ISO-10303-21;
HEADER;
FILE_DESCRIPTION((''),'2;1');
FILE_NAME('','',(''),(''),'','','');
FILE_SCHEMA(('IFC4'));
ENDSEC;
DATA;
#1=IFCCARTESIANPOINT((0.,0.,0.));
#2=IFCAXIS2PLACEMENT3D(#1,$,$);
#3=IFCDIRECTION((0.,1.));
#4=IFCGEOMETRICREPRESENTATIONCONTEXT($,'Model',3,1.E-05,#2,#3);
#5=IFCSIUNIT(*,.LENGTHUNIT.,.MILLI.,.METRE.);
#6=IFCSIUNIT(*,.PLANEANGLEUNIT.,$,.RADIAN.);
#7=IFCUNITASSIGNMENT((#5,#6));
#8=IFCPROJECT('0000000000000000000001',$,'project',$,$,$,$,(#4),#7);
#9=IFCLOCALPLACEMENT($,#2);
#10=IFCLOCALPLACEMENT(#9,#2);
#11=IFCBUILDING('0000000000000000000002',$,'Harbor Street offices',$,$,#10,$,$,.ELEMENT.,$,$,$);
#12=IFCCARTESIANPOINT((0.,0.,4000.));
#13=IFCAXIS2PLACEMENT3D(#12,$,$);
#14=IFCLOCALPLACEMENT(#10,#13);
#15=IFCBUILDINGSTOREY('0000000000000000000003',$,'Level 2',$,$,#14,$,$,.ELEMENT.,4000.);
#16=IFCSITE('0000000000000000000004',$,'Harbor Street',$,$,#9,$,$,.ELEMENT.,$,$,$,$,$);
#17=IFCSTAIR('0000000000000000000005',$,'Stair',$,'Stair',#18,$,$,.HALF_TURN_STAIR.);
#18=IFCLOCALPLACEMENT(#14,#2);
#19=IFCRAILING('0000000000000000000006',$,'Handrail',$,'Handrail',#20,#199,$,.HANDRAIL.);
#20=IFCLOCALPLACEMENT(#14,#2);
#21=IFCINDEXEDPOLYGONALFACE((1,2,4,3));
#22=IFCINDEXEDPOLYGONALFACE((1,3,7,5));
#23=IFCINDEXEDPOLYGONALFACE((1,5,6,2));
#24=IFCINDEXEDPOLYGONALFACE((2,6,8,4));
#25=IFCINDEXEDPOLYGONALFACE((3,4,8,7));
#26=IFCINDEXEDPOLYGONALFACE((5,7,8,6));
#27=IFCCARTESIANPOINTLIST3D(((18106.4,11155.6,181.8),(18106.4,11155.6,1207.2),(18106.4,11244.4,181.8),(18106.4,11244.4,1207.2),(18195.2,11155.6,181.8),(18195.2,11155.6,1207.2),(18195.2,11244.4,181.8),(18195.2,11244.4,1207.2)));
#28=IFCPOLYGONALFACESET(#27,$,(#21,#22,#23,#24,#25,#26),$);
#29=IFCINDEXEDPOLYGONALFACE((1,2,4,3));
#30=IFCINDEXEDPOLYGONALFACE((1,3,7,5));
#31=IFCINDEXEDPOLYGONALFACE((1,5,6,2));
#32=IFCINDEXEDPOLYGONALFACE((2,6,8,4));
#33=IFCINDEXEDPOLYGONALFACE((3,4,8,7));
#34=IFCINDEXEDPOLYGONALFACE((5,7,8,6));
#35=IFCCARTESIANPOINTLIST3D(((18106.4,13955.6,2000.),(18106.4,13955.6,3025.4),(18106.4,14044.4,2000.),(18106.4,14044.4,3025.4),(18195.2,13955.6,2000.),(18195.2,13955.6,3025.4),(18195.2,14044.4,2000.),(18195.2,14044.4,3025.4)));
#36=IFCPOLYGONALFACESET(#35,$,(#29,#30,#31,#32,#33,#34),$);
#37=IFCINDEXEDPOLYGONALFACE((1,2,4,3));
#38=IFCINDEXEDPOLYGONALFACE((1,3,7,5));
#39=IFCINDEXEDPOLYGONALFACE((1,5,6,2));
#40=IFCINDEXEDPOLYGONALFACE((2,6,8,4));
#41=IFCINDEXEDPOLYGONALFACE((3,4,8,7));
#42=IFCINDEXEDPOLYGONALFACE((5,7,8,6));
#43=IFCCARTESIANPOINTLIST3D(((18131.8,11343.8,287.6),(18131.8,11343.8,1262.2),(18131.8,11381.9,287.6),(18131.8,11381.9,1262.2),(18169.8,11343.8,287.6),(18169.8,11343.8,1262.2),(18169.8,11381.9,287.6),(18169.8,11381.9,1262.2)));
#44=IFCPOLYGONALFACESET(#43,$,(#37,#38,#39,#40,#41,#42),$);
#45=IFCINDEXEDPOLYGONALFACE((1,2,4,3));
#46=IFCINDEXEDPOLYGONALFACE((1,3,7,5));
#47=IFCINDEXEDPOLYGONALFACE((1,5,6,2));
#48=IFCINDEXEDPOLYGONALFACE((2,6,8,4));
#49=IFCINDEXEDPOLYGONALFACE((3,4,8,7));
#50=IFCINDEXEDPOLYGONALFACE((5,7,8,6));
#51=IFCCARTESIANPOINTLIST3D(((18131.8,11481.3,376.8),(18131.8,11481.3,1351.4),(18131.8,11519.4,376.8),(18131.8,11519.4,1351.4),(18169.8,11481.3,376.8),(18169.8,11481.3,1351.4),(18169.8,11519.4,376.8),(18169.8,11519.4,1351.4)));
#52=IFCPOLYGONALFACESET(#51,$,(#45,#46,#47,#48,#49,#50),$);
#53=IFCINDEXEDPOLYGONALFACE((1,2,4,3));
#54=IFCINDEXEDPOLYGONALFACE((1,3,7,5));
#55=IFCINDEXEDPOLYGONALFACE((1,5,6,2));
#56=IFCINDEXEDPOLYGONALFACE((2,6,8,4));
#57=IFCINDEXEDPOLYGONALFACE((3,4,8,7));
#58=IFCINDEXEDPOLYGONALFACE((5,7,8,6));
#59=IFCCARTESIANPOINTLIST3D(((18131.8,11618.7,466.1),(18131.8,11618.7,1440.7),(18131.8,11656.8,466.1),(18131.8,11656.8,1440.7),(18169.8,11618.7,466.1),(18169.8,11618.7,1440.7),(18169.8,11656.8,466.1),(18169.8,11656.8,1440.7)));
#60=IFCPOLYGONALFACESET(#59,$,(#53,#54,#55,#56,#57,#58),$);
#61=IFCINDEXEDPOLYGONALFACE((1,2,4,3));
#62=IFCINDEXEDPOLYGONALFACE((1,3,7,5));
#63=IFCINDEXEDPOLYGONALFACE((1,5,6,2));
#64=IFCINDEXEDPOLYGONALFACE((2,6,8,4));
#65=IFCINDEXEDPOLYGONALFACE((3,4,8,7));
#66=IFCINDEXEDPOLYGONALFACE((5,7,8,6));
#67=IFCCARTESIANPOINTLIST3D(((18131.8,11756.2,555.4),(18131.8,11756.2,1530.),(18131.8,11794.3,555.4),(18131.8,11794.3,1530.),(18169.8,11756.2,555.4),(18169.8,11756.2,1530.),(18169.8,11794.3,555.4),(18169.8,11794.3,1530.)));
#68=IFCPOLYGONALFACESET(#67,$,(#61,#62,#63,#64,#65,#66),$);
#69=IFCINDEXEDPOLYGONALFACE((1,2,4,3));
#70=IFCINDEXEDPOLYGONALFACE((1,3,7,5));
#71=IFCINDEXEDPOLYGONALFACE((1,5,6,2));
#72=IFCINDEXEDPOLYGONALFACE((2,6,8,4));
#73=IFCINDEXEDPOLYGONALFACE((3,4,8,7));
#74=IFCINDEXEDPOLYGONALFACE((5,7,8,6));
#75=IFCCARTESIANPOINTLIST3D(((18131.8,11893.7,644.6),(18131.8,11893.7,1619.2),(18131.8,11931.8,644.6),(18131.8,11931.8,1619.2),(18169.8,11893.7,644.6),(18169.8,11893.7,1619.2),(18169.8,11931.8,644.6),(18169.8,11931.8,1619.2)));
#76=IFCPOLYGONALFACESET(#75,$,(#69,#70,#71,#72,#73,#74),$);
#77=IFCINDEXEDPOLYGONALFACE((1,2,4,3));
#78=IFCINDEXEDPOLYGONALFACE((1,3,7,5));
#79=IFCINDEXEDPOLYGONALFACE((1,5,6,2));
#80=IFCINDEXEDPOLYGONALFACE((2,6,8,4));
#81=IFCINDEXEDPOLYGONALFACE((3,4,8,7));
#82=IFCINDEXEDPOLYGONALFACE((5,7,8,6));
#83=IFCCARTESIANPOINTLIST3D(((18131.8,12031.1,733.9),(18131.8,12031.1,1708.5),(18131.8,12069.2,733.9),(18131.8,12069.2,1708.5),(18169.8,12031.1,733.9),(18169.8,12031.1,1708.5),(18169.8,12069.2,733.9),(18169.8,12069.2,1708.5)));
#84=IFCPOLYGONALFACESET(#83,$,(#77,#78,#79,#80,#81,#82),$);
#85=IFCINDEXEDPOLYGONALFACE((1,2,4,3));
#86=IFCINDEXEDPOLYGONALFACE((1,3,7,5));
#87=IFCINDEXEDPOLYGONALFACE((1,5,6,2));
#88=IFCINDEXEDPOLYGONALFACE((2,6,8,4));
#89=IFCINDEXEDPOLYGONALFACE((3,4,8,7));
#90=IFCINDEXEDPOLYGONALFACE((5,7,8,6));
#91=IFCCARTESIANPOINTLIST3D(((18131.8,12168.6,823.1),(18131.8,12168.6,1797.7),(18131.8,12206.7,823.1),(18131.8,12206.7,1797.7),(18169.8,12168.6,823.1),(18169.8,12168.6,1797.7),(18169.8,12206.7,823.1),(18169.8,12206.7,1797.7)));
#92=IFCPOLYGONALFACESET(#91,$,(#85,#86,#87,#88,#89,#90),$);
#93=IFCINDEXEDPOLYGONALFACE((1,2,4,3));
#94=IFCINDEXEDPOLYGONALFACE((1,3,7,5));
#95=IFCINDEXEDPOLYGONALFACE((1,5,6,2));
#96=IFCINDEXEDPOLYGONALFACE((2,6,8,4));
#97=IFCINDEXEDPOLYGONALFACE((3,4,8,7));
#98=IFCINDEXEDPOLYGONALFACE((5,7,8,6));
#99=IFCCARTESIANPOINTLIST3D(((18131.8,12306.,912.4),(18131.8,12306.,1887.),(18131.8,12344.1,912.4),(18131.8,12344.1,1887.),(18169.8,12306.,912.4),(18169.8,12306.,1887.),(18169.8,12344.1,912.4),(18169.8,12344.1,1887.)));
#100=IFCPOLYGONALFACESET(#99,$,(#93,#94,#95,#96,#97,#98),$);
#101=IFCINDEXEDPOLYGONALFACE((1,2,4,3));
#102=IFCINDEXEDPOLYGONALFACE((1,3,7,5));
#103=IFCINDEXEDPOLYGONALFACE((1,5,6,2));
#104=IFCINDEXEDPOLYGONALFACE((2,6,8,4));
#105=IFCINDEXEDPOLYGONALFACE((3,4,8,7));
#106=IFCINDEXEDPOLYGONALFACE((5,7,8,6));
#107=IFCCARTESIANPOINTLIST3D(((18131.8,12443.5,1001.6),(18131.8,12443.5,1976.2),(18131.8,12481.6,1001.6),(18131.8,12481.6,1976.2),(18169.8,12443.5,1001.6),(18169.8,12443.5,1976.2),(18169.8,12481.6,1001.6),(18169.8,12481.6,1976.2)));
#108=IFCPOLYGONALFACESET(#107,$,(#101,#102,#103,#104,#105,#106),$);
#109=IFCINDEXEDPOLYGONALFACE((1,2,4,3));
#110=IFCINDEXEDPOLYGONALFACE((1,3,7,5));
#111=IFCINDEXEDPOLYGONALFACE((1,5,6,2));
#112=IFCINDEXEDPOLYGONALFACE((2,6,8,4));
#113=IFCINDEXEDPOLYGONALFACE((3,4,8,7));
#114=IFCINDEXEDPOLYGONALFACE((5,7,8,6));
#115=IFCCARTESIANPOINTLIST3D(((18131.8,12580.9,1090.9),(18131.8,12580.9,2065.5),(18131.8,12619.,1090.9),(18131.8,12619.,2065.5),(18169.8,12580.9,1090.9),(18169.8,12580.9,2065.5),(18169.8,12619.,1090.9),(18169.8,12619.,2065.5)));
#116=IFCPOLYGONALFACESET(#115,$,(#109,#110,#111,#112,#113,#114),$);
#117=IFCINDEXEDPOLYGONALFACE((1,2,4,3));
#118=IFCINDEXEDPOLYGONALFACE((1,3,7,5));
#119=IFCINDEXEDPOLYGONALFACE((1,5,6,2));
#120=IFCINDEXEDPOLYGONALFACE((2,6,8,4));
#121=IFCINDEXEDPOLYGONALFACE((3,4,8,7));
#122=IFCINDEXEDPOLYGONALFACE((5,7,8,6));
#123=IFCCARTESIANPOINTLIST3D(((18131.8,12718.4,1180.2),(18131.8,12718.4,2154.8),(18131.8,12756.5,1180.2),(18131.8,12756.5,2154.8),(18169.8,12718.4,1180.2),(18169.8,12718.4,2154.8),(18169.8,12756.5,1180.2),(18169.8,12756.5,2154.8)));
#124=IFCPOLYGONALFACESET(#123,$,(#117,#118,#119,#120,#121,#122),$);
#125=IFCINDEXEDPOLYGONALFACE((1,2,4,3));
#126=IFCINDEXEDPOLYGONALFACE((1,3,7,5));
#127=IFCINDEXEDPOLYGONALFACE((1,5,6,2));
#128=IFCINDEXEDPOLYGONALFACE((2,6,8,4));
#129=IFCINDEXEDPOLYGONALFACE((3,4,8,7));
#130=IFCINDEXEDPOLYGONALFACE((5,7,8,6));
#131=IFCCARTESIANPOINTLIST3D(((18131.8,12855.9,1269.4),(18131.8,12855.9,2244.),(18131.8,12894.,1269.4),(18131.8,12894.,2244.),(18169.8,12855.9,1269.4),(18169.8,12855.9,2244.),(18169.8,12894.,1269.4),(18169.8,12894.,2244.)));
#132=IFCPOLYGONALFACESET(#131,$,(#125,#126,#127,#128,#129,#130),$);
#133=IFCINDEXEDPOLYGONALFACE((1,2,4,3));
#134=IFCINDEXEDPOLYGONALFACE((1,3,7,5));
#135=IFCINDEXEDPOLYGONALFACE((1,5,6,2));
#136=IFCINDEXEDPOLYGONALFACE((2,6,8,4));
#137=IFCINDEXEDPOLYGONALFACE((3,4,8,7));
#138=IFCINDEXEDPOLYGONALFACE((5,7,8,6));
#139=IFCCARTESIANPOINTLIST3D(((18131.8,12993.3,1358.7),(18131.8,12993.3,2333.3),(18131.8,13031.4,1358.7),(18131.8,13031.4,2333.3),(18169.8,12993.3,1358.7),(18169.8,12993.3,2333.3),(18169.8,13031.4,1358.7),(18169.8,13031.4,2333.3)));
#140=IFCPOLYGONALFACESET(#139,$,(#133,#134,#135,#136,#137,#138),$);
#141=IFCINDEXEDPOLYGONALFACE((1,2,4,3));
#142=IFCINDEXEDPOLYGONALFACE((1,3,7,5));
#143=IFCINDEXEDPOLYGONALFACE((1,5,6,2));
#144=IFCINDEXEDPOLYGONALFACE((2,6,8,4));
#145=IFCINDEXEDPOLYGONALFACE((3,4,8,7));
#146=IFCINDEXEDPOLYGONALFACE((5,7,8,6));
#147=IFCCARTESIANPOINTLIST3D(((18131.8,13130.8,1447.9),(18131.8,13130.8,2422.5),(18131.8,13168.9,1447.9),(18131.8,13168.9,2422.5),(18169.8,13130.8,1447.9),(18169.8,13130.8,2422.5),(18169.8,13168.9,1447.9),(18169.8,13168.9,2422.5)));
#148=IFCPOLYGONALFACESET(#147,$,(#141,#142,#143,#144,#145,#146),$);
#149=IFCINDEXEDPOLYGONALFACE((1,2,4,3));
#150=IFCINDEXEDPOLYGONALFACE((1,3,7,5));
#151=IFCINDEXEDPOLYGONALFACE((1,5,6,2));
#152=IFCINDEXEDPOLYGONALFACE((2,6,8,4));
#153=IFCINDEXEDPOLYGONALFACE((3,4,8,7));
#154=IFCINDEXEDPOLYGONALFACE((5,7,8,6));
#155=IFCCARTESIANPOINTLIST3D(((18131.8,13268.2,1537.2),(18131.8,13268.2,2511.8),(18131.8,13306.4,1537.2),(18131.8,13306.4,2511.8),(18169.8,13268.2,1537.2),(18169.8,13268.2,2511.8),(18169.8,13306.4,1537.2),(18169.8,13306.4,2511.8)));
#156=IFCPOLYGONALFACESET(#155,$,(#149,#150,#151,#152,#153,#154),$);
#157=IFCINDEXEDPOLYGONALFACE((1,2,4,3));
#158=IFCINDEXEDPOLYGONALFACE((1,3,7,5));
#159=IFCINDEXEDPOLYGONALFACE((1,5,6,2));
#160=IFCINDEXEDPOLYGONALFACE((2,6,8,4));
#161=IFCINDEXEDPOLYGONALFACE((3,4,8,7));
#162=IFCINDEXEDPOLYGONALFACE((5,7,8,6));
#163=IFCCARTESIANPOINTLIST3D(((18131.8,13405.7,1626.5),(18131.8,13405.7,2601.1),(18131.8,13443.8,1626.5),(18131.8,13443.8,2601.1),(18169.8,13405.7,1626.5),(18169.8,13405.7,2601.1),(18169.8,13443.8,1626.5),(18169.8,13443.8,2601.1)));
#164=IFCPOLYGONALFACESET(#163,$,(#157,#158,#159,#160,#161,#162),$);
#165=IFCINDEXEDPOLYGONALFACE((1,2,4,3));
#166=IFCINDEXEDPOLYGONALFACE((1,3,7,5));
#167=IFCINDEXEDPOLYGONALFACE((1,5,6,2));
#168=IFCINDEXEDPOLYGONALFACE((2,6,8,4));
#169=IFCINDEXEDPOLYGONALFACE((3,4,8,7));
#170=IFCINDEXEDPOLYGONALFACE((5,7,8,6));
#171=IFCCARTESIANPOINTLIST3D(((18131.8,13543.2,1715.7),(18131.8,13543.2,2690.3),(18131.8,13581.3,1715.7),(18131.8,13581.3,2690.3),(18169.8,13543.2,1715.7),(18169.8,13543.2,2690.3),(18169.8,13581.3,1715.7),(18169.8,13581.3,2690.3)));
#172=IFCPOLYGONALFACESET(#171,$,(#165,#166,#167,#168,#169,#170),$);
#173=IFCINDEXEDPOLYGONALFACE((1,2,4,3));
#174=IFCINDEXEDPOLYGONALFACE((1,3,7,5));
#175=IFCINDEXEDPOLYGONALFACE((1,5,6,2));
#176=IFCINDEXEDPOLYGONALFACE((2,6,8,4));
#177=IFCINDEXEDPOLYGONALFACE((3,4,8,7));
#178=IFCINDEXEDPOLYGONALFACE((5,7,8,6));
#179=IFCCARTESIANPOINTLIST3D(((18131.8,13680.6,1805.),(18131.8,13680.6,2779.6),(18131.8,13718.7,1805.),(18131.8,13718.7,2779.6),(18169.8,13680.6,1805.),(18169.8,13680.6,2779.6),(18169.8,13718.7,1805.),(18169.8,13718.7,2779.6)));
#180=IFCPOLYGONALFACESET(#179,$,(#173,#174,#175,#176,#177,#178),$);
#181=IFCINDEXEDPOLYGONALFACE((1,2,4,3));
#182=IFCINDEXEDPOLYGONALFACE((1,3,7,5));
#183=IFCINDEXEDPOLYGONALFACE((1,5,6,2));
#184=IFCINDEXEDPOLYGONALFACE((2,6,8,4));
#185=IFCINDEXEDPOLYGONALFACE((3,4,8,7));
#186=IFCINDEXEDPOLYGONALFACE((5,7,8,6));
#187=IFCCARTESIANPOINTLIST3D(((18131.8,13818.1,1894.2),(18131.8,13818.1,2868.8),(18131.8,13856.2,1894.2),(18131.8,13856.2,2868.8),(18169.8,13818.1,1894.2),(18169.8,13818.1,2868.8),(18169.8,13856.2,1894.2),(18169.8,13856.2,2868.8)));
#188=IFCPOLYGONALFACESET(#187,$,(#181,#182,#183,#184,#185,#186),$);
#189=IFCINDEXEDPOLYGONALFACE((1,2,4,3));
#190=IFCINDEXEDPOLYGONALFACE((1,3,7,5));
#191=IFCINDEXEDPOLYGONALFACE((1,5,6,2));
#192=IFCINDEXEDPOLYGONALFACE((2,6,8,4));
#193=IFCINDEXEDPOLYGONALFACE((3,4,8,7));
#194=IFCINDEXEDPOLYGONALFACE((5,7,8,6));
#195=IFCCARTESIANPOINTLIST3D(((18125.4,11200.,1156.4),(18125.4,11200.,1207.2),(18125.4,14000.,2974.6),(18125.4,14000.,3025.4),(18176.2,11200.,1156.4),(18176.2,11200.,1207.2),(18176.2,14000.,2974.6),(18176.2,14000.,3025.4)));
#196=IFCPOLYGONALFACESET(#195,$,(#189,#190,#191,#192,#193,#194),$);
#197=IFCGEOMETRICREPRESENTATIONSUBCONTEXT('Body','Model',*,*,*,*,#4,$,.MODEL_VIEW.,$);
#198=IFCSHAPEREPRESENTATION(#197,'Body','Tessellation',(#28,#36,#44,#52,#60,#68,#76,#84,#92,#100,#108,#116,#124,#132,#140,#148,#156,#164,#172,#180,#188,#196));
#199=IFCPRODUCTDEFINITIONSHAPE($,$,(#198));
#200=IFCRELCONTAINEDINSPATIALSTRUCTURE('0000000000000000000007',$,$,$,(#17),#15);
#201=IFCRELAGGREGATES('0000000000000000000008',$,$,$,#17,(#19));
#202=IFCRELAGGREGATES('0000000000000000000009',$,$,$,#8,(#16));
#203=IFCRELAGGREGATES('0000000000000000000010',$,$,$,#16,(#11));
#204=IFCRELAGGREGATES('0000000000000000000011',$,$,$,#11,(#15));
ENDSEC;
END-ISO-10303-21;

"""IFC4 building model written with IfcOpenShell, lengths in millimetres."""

from ifc_helpers import new_model, si_unit, direction, frame, origin, origin_with_axes, place, context, subcontext, project, spatial, polyline, outline, extrude, element, aggregate, save


model = new_model("IFC4")

# Units and contexts
model_context = context("Model", 3, precision=1e-05, world=origin(), true_north=direction((0.0, 1.0)))
body_context = subcontext(model_context, "Body", "Model", "MODEL_VIEW")
ifc_project = project(units=[si_unit("LENGTHUNIT", "METRE", prefix="MILLI"), si_unit("PLANEANGLEUNIT", "RADIAN")], contexts=[model_context])

# Site, building, storey
site_placement = place(None, origin())
site = spatial("IfcSite", under=ifc_project, at=site_placement, Name="Harbor Street", CompositionType="ELEMENT")
building_placement = place(site_placement, origin())
building = spatial("IfcBuilding", under=site, at=building_placement, Name="Harbor Street offices", CompositionType="ELEMENT")
storey_placement = place(building_placement, frame((0.0, 0.0, 4000.0)))
storey = spatial("IfcBuildingStorey", under=building, at=storey_placement, Name="Level 2", CompositionType="ELEMENT", Elevation=4000.0)

# Stair
stair_placement = place(storey_placement, origin_with_axes())
stair = element("IfcStair", 1, at=stair_placement, inside=storey, Name="Stair", ObjectType="Stair", PredefinedType="HALF_TURN_STAIR")

# Railing
railing_1_placement = place(storey_placement, origin_with_axes())
railing_1 = element("IfcRailing", 2, at=railing_1_placement, Name="Handrail", ObjectType="Handrail", PredefinedType="HANDRAIL", context=body_context, shape_type="SweptSolid", body=[
    extrude(outline(polyline([(-44.5, -44.5), (44.5, -44.5), (44.5, 44.5), (-44.5, 44.5), (-44.5, -44.5)])), frame((18150.8, 11200.0, 181.8), z_axis=(0.0, 0.0, 1.0), x_axis=(1.0, 0.0, 0.0)), (0.0, 0.0, 1.0), 1025.4),
    extrude(outline(polyline([(-44.5, -44.5), (44.5, -44.5), (44.5, 44.5), (-44.5, 44.5), (-44.5, -44.5)])), frame((18150.8, 14000.0, 2000.0), z_axis=(0.0, 0.0, 1.0), x_axis=(1.0, 0.0, 0.0)), (0.0, 0.0, 1.0), 1025.4),
    extrude(outline(polyline([(-19.1, -19.1), (19.1, -19.1), (19.1, 19.1), (-19.1, 19.1), (-19.1, -19.1)])), frame((18150.8, 11362.9, 287.6), z_axis=(0.0, 0.0, 1.0), x_axis=(1.0, 0.0, 0.0)), (0.0, 0.0, 1.0), 974.6),
    extrude(outline(polyline([(-19.1, -19.1), (19.1, -19.1), (19.1, 19.1), (-19.1, 19.1), (-19.1, -19.1)])), frame((18150.8, 11500.3, 376.8), z_axis=(0.0, 0.0, 1.0), x_axis=(1.0, 0.0, 0.0)), (0.0, 0.0, 1.0), 974.6),
    extrude(outline(polyline([(-19.1, -19.1), (19.1, -19.1), (19.1, 19.1), (-19.1, 19.1), (-19.1, -19.1)])), frame((18150.8, 11637.8, 466.1), z_axis=(0.0, 0.0, 1.0), x_axis=(1.0, 0.0, 0.0)), (0.0, 0.0, 1.0), 974.6),
    extrude(outline(polyline([(-19.1, -19.1), (19.1, -19.1), (19.1, 19.1), (-19.1, 19.1), (-19.1, -19.1)])), frame((18150.8, 11775.2, 555.4), z_axis=(0.0, 0.0, 1.0), x_axis=(1.0, 0.0, 0.0)), (0.0, 0.0, 1.0), 974.6),
    extrude(outline(polyline([(-19.1, -19.1), (19.1, -19.1), (19.1, 19.1), (-19.1, 19.1), (-19.1, -19.1)])), frame((18150.8, 11912.7, 644.6), z_axis=(0.0, 0.0, 1.0), x_axis=(1.0, 0.0, 0.0)), (0.0, 0.0, 1.0), 974.6),
    extrude(outline(polyline([(-19.1, -19.1), (19.1, -19.1), (19.1, 19.1), (-19.1, 19.1), (-19.1, -19.1)])), frame((18150.8, 12050.2, 733.9), z_axis=(0.0, 0.0, 1.0), x_axis=(1.0, 0.0, 0.0)), (0.0, 0.0, 1.0), 974.6),
    extrude(outline(polyline([(-19.1, -19.1), (19.1, -19.1), (19.1, 19.1), (-19.1, 19.1), (-19.1, -19.1)])), frame((18150.8, 12187.6, 823.1), z_axis=(0.0, 0.0, 1.0), x_axis=(1.0, 0.0, 0.0)), (0.0, 0.0, 1.0), 974.6),
    extrude(outline(polyline([(-19.1, -19.1), (19.1, -19.1), (19.1, 19.1), (-19.1, 19.1), (-19.1, -19.1)])), frame((18150.8, 12325.1, 912.4), z_axis=(0.0, 0.0, 1.0), x_axis=(1.0, 0.0, 0.0)), (0.0, 0.0, 1.0), 974.6),
    extrude(outline(polyline([(-19.1, -19.1), (19.1, -19.1), (19.1, 19.1), (-19.1, 19.1), (-19.1, -19.1)])), frame((18150.8, 12462.5, 1001.6), z_axis=(0.0, 0.0, 1.0), x_axis=(1.0, 0.0, 0.0)), (0.0, 0.0, 1.0), 974.6),
    extrude(outline(polyline([(-19.1, -19.1), (19.1, -19.1), (19.1, 19.1), (-19.1, 19.1), (-19.1, -19.1)])), frame((18150.8, 12600.0, 1090.9), z_axis=(0.0, 0.0, 1.0), x_axis=(1.0, 0.0, 0.0)), (0.0, 0.0, 1.0), 974.6),
    extrude(outline(polyline([(-19.1, -19.1), (19.1, -19.1), (19.1, 19.1), (-19.1, 19.1), (-19.1, -19.1)])), frame((18150.8, 12737.5, 1180.2), z_axis=(0.0, 0.0, 1.0), x_axis=(1.0, 0.0, 0.0)), (0.0, 0.0, 1.0), 974.6),
    extrude(outline(polyline([(-19.1, -19.1), (19.1, -19.1), (19.1, 19.1), (-19.1, 19.1), (-19.1, -19.1)])), frame((18150.8, 12874.9, 1269.4), z_axis=(0.0, 0.0, 1.0), x_axis=(1.0, 0.0, 0.0)), (0.0, 0.0, 1.0), 974.6),
    extrude(outline(polyline([(-19.1, -19.1), (19.1, -19.1), (19.1, 19.1), (-19.1, 19.1), (-19.1, -19.1)])), frame((18150.8, 13012.4, 1358.7), z_axis=(0.0, 0.0, 1.0), x_axis=(1.0, 0.0, 0.0)), (0.0, 0.0, 1.0), 974.6),
    extrude(outline(polyline([(-19.1, -19.1), (19.1, -19.1), (19.1, 19.1), (-19.1, 19.1), (-19.1, -19.1)])), frame((18150.8, 13149.8, 1447.9), z_axis=(0.0, 0.0, 1.0), x_axis=(1.0, 0.0, 0.0)), (0.0, 0.0, 1.0), 974.6),
    extrude(outline(polyline([(-19.1, -19.1), (19.1, -19.1), (19.1, 19.1), (-19.1, 19.1), (-19.1, -19.1)])), frame((18150.8, 13287.3, 1537.2), z_axis=(0.0, 0.0, 1.0), x_axis=(1.0, 0.0, 0.0)), (0.0, 0.0, 1.0), 974.6),
    extrude(outline(polyline([(-19.1, -19.1), (19.1, -19.1), (19.1, 19.1), (-19.1, 19.1), (-19.1, -19.1)])), frame((18150.8, 13424.8, 1626.5), z_axis=(0.0, 0.0, 1.0), x_axis=(1.0, 0.0, 0.0)), (0.0, 0.0, 1.0), 974.6),
    extrude(outline(polyline([(-19.1, -19.1), (19.1, -19.1), (19.1, 19.1), (-19.1, 19.1), (-19.1, -19.1)])), frame((18150.8, 13562.2, 1715.7), z_axis=(0.0, 0.0, 1.0), x_axis=(1.0, 0.0, 0.0)), (0.0, 0.0, 1.0), 974.6),
    extrude(outline(polyline([(-19.1, -19.1), (19.1, -19.1), (19.1, 19.1), (-19.1, 19.1), (-19.1, -19.1)])), frame((18150.8, 13699.7, 1805.0), z_axis=(0.0, 0.0, 1.0), x_axis=(1.0, 0.0, 0.0)), (0.0, 0.0, 1.0), 974.6),
    extrude(outline(polyline([(-19.1, -19.1), (19.1, -19.1), (19.1, 19.1), (-19.1, 19.1), (-19.1, -19.1)])), frame((18150.8, 13837.1, 1894.2), z_axis=(0.0, 0.0, 1.0), x_axis=(1.0, 0.0, 0.0)), (0.0, 0.0, 1.0), 974.6),
    extrude(outline(polyline([(0.0, 0.0), (50.8, 0.0), (50.8, 50.8), (0.0, 50.8), (0.0, 0.0)])), frame((18176.2, 11200.0, 1156.4), z_axis=(0.0, 1.0, 0.0), x_axis=(-1.0, 0.0, 0.0)), (0.0, 0.544605, 0.838692), 3338.5),
])
aggregate(stair, [railing_1])

save(model, "model.ifc")
